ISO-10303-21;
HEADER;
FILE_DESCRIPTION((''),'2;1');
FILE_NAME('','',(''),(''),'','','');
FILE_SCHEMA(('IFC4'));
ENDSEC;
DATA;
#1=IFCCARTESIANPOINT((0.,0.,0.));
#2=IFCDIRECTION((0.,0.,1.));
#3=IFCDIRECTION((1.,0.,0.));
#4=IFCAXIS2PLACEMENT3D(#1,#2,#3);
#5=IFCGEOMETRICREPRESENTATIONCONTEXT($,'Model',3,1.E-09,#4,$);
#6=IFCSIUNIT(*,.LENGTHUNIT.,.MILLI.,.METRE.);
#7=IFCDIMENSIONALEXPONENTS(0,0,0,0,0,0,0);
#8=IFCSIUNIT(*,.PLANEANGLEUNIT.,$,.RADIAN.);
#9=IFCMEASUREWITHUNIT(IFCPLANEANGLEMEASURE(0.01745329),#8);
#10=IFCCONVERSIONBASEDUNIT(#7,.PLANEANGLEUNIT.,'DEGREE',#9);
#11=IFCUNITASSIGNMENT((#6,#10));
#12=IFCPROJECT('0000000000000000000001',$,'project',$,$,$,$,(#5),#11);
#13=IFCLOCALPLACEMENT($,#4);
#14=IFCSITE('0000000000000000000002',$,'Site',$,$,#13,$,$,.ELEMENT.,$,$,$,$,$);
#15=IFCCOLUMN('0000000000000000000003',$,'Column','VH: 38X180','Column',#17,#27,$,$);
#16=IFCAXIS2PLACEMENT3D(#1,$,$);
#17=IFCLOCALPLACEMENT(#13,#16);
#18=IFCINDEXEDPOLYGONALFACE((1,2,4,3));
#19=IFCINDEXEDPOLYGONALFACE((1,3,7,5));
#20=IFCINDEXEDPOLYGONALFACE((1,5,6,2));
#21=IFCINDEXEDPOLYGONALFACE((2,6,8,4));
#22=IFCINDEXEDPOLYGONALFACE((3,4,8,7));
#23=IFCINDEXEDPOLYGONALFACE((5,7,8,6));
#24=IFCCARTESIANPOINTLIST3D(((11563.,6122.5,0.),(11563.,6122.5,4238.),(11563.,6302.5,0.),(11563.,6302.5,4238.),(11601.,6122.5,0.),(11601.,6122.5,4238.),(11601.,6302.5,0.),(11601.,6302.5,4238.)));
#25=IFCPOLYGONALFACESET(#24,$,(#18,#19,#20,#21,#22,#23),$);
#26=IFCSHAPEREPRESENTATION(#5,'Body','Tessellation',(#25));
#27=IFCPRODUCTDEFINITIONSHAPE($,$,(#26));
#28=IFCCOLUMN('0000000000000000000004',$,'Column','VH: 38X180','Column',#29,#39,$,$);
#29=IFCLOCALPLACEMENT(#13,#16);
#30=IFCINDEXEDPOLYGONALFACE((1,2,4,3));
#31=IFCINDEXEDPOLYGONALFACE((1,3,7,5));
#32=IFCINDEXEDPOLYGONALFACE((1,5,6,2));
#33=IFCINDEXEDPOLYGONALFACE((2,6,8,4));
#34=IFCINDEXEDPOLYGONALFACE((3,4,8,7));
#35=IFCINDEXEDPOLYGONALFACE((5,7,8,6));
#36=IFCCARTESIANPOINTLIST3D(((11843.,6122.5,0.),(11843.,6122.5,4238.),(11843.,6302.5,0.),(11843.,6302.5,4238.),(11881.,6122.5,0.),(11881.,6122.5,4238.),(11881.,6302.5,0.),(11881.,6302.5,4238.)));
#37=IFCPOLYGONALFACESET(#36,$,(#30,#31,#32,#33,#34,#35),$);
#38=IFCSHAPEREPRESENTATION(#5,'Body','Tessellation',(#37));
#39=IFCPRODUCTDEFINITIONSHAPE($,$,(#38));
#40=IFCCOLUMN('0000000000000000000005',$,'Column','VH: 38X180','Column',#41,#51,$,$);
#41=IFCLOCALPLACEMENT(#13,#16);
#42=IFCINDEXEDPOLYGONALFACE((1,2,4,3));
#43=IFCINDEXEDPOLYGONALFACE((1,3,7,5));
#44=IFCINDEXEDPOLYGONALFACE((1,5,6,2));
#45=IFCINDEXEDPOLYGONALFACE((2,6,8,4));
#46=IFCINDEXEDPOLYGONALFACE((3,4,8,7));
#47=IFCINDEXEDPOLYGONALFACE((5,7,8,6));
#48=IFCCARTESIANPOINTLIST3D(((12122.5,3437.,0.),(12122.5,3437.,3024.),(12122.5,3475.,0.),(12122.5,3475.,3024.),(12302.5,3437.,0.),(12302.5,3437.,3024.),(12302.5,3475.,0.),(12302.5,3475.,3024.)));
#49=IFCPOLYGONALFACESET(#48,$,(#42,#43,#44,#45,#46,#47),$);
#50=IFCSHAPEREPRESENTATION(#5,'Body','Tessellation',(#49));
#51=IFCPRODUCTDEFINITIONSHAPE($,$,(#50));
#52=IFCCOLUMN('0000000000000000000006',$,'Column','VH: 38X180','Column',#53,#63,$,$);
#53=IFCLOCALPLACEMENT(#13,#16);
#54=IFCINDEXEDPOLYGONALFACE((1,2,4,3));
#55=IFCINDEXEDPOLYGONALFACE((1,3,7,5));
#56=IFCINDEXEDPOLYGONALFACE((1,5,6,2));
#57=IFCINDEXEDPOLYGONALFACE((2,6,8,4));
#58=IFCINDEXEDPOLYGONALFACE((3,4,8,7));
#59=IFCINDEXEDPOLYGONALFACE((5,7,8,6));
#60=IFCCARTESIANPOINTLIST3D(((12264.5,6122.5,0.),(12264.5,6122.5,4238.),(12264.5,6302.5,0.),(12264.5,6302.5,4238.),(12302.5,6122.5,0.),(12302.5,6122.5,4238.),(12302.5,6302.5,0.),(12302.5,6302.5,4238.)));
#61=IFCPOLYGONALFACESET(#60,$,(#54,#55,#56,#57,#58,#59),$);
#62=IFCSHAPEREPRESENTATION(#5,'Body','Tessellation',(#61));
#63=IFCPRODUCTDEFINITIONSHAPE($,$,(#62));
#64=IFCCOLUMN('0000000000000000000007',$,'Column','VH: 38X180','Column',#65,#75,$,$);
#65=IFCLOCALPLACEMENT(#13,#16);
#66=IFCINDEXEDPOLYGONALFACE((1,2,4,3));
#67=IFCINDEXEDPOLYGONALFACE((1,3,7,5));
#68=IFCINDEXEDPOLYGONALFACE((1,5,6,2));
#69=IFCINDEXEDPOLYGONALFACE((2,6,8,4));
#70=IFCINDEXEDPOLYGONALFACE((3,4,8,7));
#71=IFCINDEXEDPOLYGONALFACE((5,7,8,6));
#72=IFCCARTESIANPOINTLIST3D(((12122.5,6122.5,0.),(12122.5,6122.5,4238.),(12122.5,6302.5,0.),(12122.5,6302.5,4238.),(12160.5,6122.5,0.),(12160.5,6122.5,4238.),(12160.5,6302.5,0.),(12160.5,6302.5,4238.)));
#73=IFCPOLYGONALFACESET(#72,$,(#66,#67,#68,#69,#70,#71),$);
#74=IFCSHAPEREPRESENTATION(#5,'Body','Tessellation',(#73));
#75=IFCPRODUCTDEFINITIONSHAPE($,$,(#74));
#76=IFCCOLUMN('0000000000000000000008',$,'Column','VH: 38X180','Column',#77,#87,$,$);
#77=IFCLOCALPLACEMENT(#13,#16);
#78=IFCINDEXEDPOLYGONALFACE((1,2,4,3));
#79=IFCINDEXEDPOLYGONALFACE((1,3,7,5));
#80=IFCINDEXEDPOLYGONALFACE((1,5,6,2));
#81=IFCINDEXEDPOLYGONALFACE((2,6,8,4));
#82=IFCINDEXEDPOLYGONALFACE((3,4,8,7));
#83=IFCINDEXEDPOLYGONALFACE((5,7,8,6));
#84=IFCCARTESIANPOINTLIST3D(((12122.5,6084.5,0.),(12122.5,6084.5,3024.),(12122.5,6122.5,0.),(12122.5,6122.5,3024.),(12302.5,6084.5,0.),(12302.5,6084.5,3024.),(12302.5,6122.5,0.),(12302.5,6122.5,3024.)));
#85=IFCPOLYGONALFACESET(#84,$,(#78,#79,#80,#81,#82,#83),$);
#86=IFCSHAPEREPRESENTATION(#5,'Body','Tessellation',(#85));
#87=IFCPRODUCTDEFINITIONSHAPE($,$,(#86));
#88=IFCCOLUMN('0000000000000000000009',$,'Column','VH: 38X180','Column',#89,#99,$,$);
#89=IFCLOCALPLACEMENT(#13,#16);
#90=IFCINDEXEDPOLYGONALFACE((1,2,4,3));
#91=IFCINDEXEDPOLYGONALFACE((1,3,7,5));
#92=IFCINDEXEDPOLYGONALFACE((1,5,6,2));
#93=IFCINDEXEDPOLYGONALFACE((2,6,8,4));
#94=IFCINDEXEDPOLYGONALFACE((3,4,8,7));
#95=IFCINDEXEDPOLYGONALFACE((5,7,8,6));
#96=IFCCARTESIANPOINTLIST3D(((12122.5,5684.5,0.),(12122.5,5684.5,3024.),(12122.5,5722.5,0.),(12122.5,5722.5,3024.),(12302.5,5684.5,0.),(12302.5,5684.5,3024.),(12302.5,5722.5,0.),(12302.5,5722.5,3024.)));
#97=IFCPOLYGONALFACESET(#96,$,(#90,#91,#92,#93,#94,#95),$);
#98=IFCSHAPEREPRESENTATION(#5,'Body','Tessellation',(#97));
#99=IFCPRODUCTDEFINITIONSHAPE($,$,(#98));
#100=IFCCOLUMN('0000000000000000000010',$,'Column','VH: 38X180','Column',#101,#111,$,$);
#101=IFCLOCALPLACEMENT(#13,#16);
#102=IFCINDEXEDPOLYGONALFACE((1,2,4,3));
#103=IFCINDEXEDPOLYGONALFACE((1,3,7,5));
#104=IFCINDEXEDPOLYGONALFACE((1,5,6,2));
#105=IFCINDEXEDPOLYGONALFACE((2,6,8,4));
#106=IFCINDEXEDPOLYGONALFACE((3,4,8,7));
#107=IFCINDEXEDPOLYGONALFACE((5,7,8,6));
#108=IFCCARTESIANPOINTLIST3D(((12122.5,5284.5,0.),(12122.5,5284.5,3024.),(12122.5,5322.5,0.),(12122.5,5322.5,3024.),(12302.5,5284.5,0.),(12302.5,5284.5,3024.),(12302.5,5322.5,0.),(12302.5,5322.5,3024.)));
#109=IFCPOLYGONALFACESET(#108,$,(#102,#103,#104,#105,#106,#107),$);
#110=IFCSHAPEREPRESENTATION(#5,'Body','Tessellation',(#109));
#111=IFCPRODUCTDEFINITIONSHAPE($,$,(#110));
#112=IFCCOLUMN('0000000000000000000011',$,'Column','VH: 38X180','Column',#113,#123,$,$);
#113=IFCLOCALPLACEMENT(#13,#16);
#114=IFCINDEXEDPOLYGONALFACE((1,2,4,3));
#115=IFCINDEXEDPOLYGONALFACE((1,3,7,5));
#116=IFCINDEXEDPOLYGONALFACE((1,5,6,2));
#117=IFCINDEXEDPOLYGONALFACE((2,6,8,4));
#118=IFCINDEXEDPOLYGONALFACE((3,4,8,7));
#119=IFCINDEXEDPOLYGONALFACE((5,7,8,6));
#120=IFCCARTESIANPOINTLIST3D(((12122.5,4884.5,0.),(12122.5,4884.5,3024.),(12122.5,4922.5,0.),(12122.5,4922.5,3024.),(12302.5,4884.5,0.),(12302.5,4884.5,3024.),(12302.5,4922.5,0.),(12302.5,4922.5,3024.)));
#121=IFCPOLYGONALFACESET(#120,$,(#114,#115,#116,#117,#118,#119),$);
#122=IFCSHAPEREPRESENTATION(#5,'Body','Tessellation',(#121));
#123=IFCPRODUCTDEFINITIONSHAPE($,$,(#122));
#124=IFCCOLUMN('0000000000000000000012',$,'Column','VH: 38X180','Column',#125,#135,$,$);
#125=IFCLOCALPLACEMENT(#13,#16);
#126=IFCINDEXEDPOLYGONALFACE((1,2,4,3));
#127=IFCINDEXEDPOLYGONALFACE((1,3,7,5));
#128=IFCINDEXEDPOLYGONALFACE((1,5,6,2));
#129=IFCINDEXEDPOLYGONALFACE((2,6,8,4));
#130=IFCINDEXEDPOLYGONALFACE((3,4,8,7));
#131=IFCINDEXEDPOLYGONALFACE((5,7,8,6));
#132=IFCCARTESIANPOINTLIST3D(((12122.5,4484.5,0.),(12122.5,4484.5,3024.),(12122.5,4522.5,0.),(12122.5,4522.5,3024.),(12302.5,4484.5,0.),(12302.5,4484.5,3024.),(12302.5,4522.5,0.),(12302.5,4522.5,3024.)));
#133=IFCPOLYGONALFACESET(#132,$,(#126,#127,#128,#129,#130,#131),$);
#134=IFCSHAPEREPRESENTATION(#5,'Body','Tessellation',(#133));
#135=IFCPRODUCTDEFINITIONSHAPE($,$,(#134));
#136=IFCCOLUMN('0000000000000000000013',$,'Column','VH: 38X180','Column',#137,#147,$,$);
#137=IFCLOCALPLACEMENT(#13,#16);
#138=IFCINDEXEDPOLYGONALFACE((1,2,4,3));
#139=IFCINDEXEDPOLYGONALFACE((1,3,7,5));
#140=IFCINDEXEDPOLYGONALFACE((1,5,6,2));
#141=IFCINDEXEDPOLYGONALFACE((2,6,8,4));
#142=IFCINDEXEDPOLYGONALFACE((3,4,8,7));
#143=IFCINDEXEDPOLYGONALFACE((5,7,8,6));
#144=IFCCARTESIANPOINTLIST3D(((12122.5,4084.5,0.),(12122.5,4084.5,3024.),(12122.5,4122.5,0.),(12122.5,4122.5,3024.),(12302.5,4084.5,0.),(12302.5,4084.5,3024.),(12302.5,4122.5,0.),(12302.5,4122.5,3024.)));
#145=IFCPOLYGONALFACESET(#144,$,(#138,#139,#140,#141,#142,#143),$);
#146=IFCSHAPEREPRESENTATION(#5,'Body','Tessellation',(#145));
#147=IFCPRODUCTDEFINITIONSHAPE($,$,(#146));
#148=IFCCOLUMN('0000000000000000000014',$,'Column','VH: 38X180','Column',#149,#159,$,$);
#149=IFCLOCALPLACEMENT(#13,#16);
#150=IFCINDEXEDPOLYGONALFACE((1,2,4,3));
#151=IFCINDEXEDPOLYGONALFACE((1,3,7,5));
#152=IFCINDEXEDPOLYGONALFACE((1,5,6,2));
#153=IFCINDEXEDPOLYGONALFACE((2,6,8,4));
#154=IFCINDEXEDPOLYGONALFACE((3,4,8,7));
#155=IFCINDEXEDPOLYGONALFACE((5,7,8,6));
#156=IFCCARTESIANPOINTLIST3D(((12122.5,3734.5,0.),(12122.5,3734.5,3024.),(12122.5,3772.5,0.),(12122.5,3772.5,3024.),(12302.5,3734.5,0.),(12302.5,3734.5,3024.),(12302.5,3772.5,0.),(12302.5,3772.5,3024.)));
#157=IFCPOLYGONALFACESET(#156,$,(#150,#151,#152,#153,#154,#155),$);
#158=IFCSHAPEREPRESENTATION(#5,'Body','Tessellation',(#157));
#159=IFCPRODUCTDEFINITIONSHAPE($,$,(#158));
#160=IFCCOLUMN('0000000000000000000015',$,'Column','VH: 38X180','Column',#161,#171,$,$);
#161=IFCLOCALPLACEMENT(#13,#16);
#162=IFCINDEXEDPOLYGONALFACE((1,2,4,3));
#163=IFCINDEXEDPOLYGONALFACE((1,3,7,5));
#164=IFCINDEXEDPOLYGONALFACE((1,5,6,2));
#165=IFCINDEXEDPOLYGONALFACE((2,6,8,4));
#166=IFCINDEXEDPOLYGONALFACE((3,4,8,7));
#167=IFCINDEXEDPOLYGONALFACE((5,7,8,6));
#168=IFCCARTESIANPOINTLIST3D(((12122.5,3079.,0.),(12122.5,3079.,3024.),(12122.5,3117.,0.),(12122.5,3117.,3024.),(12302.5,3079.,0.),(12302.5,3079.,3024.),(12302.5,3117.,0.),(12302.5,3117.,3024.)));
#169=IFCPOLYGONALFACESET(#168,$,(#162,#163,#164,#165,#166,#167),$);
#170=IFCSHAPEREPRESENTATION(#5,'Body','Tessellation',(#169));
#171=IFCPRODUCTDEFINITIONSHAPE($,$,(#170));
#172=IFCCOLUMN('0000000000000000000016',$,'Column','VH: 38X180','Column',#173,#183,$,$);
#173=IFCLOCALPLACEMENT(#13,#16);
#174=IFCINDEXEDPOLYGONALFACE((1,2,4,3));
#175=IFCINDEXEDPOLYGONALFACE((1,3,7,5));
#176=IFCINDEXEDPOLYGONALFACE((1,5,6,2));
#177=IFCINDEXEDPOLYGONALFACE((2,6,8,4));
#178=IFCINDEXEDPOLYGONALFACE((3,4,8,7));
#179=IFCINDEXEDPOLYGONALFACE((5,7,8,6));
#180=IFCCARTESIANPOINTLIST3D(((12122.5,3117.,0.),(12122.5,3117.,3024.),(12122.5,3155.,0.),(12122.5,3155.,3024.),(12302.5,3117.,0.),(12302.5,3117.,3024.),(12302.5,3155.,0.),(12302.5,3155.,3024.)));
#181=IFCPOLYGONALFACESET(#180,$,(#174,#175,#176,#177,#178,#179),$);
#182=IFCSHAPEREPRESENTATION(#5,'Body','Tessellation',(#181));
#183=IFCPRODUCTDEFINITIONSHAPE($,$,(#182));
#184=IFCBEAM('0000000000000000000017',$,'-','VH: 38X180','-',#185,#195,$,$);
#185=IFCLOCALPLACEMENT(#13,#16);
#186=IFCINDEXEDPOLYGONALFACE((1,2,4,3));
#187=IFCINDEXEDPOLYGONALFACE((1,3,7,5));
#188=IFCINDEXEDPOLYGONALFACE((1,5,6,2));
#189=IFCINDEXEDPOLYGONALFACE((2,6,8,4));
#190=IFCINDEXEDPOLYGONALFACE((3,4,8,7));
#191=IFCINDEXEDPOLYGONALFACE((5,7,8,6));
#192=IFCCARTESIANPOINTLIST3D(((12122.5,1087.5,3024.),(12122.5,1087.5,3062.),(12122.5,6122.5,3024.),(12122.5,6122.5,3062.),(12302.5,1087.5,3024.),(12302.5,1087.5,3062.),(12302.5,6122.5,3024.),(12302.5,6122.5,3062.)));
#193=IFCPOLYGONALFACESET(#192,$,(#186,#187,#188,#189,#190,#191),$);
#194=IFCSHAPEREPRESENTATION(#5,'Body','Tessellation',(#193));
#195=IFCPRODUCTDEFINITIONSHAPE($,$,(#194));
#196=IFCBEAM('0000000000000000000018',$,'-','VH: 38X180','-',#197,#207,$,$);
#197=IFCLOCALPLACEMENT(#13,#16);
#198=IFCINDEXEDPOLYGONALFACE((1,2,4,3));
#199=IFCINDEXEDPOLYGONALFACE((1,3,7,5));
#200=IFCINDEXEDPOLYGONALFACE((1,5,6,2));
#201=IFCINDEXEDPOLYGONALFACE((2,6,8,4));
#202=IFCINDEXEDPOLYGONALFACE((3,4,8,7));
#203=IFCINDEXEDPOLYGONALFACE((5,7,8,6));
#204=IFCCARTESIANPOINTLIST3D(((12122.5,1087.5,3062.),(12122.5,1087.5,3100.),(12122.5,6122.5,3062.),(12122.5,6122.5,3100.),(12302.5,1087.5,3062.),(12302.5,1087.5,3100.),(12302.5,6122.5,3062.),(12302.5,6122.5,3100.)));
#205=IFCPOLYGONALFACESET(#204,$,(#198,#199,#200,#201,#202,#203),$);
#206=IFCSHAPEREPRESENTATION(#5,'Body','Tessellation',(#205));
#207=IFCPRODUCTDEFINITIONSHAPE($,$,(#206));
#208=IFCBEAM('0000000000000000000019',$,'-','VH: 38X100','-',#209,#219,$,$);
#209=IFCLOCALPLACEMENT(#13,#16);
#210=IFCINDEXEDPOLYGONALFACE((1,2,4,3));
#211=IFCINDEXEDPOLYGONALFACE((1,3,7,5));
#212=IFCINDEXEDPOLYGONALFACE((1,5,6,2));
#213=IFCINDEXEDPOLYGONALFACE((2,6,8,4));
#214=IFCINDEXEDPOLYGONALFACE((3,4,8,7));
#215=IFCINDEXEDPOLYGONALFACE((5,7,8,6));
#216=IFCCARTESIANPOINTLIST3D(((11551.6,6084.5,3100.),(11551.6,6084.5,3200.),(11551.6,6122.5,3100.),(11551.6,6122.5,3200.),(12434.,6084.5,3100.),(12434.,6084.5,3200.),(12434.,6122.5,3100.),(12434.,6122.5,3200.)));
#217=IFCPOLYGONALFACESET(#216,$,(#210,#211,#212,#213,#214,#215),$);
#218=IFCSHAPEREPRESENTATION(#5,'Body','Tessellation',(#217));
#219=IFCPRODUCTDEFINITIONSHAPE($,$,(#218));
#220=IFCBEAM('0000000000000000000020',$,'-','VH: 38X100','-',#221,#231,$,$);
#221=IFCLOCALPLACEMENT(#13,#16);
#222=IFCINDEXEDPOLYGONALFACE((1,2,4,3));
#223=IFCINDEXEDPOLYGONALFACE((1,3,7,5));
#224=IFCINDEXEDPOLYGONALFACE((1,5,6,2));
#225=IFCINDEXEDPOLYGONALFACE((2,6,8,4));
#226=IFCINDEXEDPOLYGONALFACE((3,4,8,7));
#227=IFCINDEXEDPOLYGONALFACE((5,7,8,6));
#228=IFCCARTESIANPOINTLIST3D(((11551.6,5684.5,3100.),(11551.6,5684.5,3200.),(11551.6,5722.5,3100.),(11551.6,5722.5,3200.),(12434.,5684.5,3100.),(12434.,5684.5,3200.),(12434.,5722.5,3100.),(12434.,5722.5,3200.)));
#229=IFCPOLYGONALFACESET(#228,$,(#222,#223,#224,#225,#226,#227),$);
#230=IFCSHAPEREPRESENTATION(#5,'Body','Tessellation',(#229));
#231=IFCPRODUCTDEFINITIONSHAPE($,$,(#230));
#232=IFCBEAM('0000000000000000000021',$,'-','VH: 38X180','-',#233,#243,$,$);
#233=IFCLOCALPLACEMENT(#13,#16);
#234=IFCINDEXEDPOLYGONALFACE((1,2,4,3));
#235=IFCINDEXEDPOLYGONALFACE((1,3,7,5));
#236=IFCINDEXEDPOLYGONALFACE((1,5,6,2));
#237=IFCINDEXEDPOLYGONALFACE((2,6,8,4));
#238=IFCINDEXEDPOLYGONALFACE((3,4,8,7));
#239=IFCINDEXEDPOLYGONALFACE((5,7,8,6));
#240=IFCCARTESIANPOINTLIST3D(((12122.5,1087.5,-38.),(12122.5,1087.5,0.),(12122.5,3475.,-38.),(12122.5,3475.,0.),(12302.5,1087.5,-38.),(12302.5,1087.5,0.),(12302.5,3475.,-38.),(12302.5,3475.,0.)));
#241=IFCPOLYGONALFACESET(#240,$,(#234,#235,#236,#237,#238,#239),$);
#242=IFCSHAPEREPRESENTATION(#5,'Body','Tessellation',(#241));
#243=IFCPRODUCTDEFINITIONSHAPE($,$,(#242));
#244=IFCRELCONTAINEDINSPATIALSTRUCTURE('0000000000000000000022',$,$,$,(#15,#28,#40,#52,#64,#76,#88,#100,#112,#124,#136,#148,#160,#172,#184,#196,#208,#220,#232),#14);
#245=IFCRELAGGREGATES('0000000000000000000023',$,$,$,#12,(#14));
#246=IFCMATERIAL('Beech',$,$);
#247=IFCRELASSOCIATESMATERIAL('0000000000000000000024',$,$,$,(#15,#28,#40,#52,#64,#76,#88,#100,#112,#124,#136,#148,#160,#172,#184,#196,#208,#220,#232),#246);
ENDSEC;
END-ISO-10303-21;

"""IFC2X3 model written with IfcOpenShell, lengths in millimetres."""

from ifc_helpers import new_model, entity, si_unit, converted_unit, frame, origin, origin_with_axes, origin_2d, place, context, project, spatial, rectangle, extrude, material, element, save


model = new_model("IFC2X3")

# Units and contexts
model_context = context("Model", 3, precision=1e-09, world=origin_with_axes())
ifc_project = project(units=[si_unit("LENGTHUNIT", "METRE", prefix="MILLI"), converted_unit("PLANEANGLEUNIT", "DEGREE", entity("IfcPlaneAngleMeasure", 0.01745329), si_unit("PLANEANGLEUNIT", "RADIAN"), dimensions=[0, 0, 0, 0, 0, 0, 0])], contexts=[model_context])

# Site
site_placement = place(None, origin_with_axes())
site = spatial("IfcSite", under=ifc_project, at=site_placement, Name="Site", CompositionType="ELEMENT")

# Columns
ifc_material_1 = material(Name="Beech")
for number, where, z_axis, x_axis, name in (
    (1, (11582.0, 6212.5, 0.0), (0.0, 0.0, -1.0), (-1.0, 0.0, 0.0), "Column"),
    (2, (11862.0, 6212.5, 0.0), (0.0, 0.0, -1.0), (-1.0, 0.0, 0.0), "Column"),
):
    element("IfcColumn", number, at=place(None, frame(where, z_axis=z_axis, x_axis=x_axis)), inside=site, material=ifc_material_1, Name=name, Description="VH: 38X180", ObjectType="Column", context=model_context, shape_type="SweptSolid", body=[
        extrude(rectangle(XDim=38.0, YDim=180.0, at=origin_2d()), origin(), (0.0, 0.0, -1.0), 4238.0),
    ])
column_1_placement = place(None, frame((12212.5, 3456.0, 0.0), z_axis=(0.0, 0.0, -1.0), x_axis=(0.0, -1.0, 0.0)))
element("IfcColumn", 3, at=column_1_placement, inside=site, material=ifc_material_1, Name="Column", Description="VH: 38X180", ObjectType="Column", context=model_context, shape_type="SweptSolid", body=[
    extrude(rectangle(XDim=38.0, YDim=180.0, at=origin_2d()), origin(), (0.0, 0.0, -1.0), 3024.0),
])
for number, where, z_axis, x_axis, name in (
    (4, (12283.5, 6212.5, 0.0), (0.0, 0.0, -1.0), (-1.0, 0.0, 0.0), "Column"),
    (5, (12141.5, 6212.5, 0.0), (0.0, 0.0, -1.0), (-1.0, 0.0, 0.0), "Column"),
):
    element("IfcColumn", number, at=place(None, frame(where, z_axis=z_axis, x_axis=x_axis)), inside=site, material=ifc_material_1, Name=name, Description="VH: 38X180", ObjectType="Column", context=model_context, shape_type="SweptSolid", body=[
        extrude(rectangle(XDim=38.0, YDim=180.0, at=origin_2d()), origin(), (0.0, 0.0, -1.0), 4238.0),
    ])
for number, where, z_axis, x_axis, name in (
    (6, (12212.5, 6103.5, 0.0), (0.0, 0.0, -1.0), (0.0, -1.0, 0.0), "Column"),
    (7, (12212.5, 5703.5, 0.0), (0.0, 0.0, -1.0), (0.0, -1.0, 0.0), "Column"),
    (8, (12212.5, 5303.5, 0.0), (0.0, 0.0, -1.0), (0.0, -1.0, 0.0), "Column"),
    (9, (12212.5, 4903.5, 0.0), (0.0, 0.0, -1.0), (0.0, -1.0, 0.0), "Column"),
    (10, (12212.5, 4503.5, 0.0), (0.0, 0.0, -1.0), (0.0, -1.0, 0.0), "Column"),
    (11, (12212.5, 4103.5, 0.0), (0.0, 0.0, -1.0), (0.0, -1.0, 0.0), "Column"),
    (12, (12212.5, 3753.5, 0.0), (0.0, 0.0, -1.0), (0.0, -1.0, 0.0), "Column"),
    (13, (12212.5, 3098.0, 0.0), (0.0, 0.0, -1.0), (0.0, -1.0, 0.0), "Column"),
    (14, (12212.5, 3136.0, 0.0), (0.0, 0.0, -1.0), (0.0, -1.0, 0.0), "Column"),
):
    element("IfcColumn", number, at=place(None, frame(where, z_axis=z_axis, x_axis=x_axis)), inside=site, material=ifc_material_1, Name=name, Description="VH: 38X180", ObjectType="Column", context=model_context, shape_type="SweptSolid", body=[
        extrude(rectangle(XDim=38.0, YDim=180.0, at=origin_2d()), origin(), (0.0, 0.0, -1.0), 3024.0),
    ])

# Beams
for number, where, z_axis, x_axis, name in (
    (15, (12212.5, 6122.5, 3043.0), (0.0, -1.0, 0.0), (0.0, 0.0, 1.0), "-"),
    (16, (12212.5, 6122.5, 3081.0), (0.0, -1.0, 0.0), (0.0, 0.0, 1.0), "-"),
):
    element("IfcBeam", number, at=place(None, frame(where, z_axis=z_axis, x_axis=x_axis)), inside=site, material=ifc_material_1, Name=name, Description="VH: 38X180", ObjectType="-", context=model_context, shape_type="SweptSolid", body=[
        extrude(rectangle(XDim=38.0, YDim=180.0, at=origin_2d()), origin(), (0.0, 0.0, 1.0), 5035.0),
    ])
beam_1_placement = place(None, frame((11551.6, 6103.5, 3150.0), z_axis=(1.0, 0.000018, 0.0), x_axis=(-0.000018, 1.0, 0.0)))
element("IfcBeam", 17, at=beam_1_placement, inside=site, material=ifc_material_1, Name="-", Description="VH: 38X100", ObjectType="-", context=model_context, shape_type="SweptSolid", body=[
    extrude(rectangle(XDim=38.0, YDim=100.0, at=origin_2d()), origin(), (0.0, 0.0, 1.0), 882.4),
])
beam_2_placement = place(None, frame((11551.6, 5703.5, 3150.0), z_axis=(1.0, 0.000018, 0.0), x_axis=(-0.000018, 1.0, 0.0)))
element("IfcBeam", 18, at=beam_2_placement, inside=site, material=ifc_material_1, Name="-", Description="VH: 38X100", ObjectType="-", context=model_context, shape_type="SweptSolid", body=[
    extrude(rectangle(XDim=38.0, YDim=100.0, at=origin_2d()), origin(), (0.0, 0.0, 1.0), 882.4),
])
beam_3_placement = place(None, frame((12212.5, 3475.0, -19.0), z_axis=(-0.000013, -1.0, 0.0), x_axis=(0.0, 0.0, 1.0)))
element("IfcBeam", 19, at=beam_3_placement, inside=site, material=ifc_material_1, Name="-", Description="VH: 38X180", ObjectType="-", context=model_context, shape_type="SweptSolid", body=[
    extrude(rectangle(XDim=38.0, YDim=180.0, at=origin_2d()), origin(), (0.0, 0.0, 1.0), 2387.5),
])

save(model, "model.ifc")
